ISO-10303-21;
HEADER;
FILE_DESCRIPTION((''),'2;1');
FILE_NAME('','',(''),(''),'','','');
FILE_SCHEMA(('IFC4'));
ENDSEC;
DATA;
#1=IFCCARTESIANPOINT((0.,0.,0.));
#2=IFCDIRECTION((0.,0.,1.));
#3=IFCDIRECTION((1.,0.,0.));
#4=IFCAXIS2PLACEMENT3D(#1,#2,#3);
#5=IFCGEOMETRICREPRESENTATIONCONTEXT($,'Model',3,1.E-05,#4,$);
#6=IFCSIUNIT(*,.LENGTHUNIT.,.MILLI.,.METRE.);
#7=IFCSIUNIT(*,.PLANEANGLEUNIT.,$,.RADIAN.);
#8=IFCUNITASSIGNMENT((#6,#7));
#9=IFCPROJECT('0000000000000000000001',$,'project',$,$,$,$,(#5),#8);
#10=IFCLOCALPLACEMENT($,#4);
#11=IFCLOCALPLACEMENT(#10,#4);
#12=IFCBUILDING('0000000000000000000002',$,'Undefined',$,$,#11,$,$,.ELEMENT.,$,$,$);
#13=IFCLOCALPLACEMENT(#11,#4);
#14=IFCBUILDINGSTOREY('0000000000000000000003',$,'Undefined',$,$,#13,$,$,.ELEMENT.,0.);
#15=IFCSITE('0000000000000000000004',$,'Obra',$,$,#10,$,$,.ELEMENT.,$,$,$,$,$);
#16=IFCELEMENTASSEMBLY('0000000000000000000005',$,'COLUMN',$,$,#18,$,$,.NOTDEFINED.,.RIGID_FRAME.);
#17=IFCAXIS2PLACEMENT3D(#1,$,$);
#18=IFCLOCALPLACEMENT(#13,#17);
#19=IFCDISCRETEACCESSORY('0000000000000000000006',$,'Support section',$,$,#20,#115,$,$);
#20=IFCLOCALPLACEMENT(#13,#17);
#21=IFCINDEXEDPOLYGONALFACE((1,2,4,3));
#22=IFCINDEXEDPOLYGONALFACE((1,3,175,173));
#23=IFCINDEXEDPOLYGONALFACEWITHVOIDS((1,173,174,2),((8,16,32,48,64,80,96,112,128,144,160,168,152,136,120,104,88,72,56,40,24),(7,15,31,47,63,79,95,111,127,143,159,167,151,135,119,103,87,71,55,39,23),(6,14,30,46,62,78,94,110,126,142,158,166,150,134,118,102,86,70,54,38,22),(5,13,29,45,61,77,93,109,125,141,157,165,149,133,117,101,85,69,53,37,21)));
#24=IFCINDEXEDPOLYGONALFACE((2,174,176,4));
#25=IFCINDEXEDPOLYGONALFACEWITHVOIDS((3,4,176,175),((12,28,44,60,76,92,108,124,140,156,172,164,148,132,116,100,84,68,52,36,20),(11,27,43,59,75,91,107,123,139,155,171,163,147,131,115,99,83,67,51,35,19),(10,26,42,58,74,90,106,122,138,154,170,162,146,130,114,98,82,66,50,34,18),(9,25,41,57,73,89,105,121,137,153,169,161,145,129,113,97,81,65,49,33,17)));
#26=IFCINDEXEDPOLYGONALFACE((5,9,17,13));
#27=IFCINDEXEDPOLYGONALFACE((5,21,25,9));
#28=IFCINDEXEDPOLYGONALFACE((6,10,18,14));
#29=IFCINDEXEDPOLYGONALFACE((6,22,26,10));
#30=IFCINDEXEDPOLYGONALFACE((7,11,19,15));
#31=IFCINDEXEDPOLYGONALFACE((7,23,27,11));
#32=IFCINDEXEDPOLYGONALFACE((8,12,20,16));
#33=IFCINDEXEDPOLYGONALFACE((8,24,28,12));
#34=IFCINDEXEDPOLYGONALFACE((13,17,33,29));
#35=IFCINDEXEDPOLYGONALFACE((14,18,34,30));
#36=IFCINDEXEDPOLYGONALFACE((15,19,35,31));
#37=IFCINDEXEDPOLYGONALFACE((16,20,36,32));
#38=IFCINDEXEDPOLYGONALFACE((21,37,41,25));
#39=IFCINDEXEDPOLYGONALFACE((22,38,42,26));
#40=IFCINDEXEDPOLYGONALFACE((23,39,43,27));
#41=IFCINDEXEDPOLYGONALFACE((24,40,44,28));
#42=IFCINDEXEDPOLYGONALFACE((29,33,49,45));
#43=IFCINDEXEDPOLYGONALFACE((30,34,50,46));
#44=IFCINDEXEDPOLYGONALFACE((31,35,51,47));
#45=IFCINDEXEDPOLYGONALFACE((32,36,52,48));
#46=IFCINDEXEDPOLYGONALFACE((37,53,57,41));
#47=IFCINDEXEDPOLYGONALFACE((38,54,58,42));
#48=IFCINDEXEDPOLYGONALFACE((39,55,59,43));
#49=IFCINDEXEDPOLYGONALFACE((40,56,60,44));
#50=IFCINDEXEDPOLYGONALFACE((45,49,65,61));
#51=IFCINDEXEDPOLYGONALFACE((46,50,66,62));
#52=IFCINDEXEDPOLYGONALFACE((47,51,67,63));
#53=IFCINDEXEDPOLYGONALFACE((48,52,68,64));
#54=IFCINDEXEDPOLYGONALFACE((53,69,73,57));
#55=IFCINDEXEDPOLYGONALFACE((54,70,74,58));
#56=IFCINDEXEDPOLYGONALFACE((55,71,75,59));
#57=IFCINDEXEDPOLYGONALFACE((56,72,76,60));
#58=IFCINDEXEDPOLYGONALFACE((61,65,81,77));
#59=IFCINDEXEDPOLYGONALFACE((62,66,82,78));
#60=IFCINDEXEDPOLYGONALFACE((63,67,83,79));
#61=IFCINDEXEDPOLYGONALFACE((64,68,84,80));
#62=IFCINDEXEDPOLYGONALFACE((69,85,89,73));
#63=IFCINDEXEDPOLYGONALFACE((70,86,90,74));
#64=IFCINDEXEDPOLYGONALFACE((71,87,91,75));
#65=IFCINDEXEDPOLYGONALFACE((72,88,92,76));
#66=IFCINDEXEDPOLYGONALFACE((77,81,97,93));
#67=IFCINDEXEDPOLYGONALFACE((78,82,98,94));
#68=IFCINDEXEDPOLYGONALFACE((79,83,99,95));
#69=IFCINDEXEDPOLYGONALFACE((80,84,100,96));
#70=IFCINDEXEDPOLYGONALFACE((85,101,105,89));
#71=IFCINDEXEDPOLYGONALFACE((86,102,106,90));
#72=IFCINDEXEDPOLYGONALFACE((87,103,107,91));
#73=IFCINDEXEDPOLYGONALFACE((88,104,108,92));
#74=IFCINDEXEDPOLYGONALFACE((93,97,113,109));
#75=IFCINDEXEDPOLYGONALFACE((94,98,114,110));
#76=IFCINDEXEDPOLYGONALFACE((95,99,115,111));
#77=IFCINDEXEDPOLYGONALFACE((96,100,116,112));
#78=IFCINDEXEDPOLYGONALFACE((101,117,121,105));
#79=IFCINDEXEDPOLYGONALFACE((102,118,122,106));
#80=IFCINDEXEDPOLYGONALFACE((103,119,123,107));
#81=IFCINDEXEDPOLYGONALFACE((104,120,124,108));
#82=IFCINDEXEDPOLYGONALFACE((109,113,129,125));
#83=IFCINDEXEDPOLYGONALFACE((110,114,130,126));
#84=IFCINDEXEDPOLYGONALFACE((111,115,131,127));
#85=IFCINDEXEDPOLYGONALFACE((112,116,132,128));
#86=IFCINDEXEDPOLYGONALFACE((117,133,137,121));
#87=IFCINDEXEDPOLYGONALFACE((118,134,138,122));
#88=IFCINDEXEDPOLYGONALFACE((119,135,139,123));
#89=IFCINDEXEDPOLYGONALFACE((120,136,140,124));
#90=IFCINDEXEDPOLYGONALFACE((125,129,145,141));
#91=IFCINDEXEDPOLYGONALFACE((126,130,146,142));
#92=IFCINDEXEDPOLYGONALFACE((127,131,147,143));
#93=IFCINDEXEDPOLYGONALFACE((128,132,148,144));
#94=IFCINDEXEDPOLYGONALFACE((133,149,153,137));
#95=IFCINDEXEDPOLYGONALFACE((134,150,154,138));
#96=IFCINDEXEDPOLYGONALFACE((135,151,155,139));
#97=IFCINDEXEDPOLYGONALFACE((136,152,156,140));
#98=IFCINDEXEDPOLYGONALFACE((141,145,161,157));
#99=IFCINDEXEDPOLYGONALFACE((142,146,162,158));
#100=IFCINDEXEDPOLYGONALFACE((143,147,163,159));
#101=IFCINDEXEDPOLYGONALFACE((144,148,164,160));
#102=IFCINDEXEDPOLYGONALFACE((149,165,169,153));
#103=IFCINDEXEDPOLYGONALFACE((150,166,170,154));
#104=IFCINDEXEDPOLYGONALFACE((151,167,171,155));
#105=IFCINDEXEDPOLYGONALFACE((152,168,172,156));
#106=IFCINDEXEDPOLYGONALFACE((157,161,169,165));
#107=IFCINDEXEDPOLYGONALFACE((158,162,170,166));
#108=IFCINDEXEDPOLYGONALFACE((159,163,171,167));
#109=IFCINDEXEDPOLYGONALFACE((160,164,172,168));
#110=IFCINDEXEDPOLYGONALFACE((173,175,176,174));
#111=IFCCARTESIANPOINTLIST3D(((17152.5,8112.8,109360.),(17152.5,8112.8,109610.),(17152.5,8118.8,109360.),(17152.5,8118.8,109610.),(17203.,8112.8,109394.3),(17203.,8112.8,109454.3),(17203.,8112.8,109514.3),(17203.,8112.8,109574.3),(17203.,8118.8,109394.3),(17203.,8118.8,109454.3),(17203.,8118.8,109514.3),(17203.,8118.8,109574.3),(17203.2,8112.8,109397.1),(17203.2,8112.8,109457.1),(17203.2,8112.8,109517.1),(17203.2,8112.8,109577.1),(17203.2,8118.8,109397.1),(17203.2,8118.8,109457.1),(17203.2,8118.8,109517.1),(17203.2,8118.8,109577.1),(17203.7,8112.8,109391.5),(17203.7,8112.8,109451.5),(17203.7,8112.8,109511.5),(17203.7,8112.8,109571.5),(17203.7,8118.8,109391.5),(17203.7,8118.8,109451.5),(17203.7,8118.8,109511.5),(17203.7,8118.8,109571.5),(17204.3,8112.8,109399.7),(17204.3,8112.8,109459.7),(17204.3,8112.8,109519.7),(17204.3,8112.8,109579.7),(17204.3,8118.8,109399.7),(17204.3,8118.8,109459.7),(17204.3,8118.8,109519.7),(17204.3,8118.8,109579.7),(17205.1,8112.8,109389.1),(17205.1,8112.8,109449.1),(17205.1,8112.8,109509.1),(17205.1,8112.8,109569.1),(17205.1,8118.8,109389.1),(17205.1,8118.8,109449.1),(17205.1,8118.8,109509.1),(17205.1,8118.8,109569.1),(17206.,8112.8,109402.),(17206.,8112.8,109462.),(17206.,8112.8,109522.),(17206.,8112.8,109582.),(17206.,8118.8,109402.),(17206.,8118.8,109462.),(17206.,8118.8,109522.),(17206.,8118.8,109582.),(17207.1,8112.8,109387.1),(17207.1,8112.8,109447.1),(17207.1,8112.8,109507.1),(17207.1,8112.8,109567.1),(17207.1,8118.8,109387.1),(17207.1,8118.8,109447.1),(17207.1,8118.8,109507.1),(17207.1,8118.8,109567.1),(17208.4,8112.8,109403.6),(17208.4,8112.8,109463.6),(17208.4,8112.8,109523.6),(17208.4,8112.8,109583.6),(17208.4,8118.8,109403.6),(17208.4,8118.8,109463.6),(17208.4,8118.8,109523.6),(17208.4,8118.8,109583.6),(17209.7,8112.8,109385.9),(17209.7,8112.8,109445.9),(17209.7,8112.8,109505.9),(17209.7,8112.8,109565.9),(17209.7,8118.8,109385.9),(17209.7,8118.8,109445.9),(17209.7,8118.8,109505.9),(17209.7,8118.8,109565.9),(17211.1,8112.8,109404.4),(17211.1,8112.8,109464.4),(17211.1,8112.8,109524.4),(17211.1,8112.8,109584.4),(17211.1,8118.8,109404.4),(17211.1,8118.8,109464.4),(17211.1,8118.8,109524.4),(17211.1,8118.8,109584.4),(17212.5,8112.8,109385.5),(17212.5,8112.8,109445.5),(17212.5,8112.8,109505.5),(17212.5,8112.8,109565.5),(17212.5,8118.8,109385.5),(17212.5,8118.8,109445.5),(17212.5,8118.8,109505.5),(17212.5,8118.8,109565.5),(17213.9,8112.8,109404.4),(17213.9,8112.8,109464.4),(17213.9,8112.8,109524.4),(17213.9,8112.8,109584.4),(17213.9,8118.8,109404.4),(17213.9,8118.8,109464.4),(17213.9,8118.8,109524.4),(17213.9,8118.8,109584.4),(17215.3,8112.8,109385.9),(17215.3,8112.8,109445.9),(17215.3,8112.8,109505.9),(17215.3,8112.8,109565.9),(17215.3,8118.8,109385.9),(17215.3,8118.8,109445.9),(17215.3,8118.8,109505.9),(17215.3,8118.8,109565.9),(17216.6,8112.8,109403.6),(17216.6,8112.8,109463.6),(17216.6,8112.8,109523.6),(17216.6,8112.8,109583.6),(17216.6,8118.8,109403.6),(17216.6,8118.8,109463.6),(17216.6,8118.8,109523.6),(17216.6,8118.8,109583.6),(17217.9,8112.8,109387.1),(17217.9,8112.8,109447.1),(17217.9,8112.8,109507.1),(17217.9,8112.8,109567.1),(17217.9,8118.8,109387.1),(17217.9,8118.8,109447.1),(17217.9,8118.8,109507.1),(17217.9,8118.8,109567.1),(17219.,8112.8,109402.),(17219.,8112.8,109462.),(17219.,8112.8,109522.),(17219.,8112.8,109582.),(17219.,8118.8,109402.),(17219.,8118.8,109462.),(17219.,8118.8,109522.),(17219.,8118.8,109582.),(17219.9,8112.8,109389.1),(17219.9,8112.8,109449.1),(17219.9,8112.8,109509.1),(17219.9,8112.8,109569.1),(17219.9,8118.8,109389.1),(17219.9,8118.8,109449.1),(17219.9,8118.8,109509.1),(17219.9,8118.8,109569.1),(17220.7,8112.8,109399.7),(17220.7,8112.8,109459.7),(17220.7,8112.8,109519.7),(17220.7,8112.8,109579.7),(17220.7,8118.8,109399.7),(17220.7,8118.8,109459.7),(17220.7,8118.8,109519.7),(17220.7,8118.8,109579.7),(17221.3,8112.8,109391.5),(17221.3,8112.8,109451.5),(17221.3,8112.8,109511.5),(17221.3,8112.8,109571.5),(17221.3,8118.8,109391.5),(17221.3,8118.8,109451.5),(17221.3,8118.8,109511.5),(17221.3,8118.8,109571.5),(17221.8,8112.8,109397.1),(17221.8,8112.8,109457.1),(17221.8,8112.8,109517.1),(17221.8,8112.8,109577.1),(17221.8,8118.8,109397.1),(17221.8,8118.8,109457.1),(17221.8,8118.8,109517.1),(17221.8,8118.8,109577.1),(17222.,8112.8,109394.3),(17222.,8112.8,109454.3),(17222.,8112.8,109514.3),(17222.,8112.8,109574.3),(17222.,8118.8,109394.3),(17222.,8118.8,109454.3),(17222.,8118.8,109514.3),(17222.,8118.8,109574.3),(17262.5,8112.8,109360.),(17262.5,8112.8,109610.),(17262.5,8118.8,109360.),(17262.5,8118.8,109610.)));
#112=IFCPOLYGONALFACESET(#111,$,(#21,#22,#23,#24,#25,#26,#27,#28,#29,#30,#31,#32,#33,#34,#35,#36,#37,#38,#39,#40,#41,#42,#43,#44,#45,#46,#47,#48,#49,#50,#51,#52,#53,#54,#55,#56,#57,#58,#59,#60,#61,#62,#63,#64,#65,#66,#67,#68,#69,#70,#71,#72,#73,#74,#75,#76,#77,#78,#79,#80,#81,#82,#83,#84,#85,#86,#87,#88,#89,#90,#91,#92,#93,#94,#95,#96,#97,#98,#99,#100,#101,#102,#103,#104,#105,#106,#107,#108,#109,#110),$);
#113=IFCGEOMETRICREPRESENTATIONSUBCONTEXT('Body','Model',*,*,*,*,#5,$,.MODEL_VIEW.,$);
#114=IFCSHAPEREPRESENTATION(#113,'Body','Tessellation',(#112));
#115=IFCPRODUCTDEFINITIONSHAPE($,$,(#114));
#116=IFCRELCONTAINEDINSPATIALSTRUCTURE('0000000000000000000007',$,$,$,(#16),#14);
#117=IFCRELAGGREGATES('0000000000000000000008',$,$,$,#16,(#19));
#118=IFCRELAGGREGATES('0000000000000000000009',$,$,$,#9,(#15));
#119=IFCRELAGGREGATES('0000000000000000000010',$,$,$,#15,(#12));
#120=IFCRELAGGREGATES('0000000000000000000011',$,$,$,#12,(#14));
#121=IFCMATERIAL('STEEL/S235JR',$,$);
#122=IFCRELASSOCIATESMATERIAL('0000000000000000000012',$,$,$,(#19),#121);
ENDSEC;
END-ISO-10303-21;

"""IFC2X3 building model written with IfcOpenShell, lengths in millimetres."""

from ifc_helpers import new_model, si_unit, frame, origin_with_axes, origin_2d_with_axis, place, context, subcontext, project, spatial, rectangle, circle, extrude, source, transform, mapped, material, element, aggregate, save


model = new_model("IFC2X3")

# Units and contexts
model_context = context("Model", 3, precision=1e-05, world=origin_with_axes())
body_context = subcontext(model_context, "Body", "Model", "MODEL_VIEW")
ifc_project = project(units=[si_unit("LENGTHUNIT", "METRE", prefix="MILLI"), si_unit("PLANEANGLEUNIT", "RADIAN")], contexts=[model_context])

# Site, building, storey
site_placement = place(None, origin_with_axes())
site = spatial("IfcSite", under=ifc_project, at=site_placement, Name="Obra", CompositionType="ELEMENT")
building_placement = place(site_placement, origin_with_axes())
building = spatial("IfcBuilding", under=site, at=building_placement, Name="Undefined", CompositionType="ELEMENT")
storey_placement = place(building_placement, origin_with_axes())
storey = spatial("IfcBuildingStorey", under=building, at=storey_placement, Name="Undefined", CompositionType="ELEMENT", Elevation=0.0)

# Element assembly
assembly_1_placement = place(storey_placement, origin_with_axes())
assembly_1 = element("IfcElementAssembly", 1, at=assembly_1_placement, inside=storey, Name="COLUMN", AssemblyPlace="NOTDEFINED", PredefinedType="RIGID_FRAME")
ifc_material_1 = material(Name="STEEL/S235JR")

# Shared definitions
shared_shape_1 = source(origin_with_axes(), body_context, "Body", "SweptSolid", [
    extrude(circle(Radius=9.5, at=origin_2d_with_axis()), frame((0.0, -9.9, 0.0), z_axis=(0.0, 1.0, 0.0), x_axis=(1.0, 0.0, 0.0)), (0.0, 0.0, 1.0), 6.2),
])

# Discrete accessory, opening
discrete_accessory_1_placement = place(assembly_1_placement, frame((17207.5, 8115.8, 109360.0), z_axis=(0.0, 0.0, 1.0), x_axis=(-1.0, 0.0, 0.0)))
discrete_accessory_1 = element("IfcDiscreteAccessory", 2, at=discrete_accessory_1_placement, material=ifc_material_1, Name="Support section", context=body_context, shape_type="SweptSolid", body=[
    extrude(rectangle(XDim=6.0, YDim=110.0, at=origin_2d_with_axis()), frame((0.0, 0.0, 250.0), z_axis=(0.0, 0.0, -1.0), x_axis=(0.0, 1.0, 0.0)), (0.0, 0.0, 1.0), 250.0),
])
opening_1_placement = place(assembly_1_placement, frame((17162.5, 8122.5, 109650.0), z_axis=(1.0, 0.0, 0.0), x_axis=(0.0, 0.0, -1.0)))
element("IfcOpeningElement", 3, at=opening_1_placement, cuts=discrete_accessory_1, ObjectType="Opening", context=body_context, shape_type="MappedRepresentation", body=[
    mapped(shared_shape_1, transform((75.0, 0.0, 50.0))),
    mapped(shared_shape_1, transform((135.0, 0.0, 50.0))),
    mapped(shared_shape_1, transform((195.0, 0.0, 50.0))),
    mapped(shared_shape_1, transform((255.0, 0.0, 50.0))),
])
aggregate(assembly_1, [discrete_accessory_1])

save(model, "model.ifc")
